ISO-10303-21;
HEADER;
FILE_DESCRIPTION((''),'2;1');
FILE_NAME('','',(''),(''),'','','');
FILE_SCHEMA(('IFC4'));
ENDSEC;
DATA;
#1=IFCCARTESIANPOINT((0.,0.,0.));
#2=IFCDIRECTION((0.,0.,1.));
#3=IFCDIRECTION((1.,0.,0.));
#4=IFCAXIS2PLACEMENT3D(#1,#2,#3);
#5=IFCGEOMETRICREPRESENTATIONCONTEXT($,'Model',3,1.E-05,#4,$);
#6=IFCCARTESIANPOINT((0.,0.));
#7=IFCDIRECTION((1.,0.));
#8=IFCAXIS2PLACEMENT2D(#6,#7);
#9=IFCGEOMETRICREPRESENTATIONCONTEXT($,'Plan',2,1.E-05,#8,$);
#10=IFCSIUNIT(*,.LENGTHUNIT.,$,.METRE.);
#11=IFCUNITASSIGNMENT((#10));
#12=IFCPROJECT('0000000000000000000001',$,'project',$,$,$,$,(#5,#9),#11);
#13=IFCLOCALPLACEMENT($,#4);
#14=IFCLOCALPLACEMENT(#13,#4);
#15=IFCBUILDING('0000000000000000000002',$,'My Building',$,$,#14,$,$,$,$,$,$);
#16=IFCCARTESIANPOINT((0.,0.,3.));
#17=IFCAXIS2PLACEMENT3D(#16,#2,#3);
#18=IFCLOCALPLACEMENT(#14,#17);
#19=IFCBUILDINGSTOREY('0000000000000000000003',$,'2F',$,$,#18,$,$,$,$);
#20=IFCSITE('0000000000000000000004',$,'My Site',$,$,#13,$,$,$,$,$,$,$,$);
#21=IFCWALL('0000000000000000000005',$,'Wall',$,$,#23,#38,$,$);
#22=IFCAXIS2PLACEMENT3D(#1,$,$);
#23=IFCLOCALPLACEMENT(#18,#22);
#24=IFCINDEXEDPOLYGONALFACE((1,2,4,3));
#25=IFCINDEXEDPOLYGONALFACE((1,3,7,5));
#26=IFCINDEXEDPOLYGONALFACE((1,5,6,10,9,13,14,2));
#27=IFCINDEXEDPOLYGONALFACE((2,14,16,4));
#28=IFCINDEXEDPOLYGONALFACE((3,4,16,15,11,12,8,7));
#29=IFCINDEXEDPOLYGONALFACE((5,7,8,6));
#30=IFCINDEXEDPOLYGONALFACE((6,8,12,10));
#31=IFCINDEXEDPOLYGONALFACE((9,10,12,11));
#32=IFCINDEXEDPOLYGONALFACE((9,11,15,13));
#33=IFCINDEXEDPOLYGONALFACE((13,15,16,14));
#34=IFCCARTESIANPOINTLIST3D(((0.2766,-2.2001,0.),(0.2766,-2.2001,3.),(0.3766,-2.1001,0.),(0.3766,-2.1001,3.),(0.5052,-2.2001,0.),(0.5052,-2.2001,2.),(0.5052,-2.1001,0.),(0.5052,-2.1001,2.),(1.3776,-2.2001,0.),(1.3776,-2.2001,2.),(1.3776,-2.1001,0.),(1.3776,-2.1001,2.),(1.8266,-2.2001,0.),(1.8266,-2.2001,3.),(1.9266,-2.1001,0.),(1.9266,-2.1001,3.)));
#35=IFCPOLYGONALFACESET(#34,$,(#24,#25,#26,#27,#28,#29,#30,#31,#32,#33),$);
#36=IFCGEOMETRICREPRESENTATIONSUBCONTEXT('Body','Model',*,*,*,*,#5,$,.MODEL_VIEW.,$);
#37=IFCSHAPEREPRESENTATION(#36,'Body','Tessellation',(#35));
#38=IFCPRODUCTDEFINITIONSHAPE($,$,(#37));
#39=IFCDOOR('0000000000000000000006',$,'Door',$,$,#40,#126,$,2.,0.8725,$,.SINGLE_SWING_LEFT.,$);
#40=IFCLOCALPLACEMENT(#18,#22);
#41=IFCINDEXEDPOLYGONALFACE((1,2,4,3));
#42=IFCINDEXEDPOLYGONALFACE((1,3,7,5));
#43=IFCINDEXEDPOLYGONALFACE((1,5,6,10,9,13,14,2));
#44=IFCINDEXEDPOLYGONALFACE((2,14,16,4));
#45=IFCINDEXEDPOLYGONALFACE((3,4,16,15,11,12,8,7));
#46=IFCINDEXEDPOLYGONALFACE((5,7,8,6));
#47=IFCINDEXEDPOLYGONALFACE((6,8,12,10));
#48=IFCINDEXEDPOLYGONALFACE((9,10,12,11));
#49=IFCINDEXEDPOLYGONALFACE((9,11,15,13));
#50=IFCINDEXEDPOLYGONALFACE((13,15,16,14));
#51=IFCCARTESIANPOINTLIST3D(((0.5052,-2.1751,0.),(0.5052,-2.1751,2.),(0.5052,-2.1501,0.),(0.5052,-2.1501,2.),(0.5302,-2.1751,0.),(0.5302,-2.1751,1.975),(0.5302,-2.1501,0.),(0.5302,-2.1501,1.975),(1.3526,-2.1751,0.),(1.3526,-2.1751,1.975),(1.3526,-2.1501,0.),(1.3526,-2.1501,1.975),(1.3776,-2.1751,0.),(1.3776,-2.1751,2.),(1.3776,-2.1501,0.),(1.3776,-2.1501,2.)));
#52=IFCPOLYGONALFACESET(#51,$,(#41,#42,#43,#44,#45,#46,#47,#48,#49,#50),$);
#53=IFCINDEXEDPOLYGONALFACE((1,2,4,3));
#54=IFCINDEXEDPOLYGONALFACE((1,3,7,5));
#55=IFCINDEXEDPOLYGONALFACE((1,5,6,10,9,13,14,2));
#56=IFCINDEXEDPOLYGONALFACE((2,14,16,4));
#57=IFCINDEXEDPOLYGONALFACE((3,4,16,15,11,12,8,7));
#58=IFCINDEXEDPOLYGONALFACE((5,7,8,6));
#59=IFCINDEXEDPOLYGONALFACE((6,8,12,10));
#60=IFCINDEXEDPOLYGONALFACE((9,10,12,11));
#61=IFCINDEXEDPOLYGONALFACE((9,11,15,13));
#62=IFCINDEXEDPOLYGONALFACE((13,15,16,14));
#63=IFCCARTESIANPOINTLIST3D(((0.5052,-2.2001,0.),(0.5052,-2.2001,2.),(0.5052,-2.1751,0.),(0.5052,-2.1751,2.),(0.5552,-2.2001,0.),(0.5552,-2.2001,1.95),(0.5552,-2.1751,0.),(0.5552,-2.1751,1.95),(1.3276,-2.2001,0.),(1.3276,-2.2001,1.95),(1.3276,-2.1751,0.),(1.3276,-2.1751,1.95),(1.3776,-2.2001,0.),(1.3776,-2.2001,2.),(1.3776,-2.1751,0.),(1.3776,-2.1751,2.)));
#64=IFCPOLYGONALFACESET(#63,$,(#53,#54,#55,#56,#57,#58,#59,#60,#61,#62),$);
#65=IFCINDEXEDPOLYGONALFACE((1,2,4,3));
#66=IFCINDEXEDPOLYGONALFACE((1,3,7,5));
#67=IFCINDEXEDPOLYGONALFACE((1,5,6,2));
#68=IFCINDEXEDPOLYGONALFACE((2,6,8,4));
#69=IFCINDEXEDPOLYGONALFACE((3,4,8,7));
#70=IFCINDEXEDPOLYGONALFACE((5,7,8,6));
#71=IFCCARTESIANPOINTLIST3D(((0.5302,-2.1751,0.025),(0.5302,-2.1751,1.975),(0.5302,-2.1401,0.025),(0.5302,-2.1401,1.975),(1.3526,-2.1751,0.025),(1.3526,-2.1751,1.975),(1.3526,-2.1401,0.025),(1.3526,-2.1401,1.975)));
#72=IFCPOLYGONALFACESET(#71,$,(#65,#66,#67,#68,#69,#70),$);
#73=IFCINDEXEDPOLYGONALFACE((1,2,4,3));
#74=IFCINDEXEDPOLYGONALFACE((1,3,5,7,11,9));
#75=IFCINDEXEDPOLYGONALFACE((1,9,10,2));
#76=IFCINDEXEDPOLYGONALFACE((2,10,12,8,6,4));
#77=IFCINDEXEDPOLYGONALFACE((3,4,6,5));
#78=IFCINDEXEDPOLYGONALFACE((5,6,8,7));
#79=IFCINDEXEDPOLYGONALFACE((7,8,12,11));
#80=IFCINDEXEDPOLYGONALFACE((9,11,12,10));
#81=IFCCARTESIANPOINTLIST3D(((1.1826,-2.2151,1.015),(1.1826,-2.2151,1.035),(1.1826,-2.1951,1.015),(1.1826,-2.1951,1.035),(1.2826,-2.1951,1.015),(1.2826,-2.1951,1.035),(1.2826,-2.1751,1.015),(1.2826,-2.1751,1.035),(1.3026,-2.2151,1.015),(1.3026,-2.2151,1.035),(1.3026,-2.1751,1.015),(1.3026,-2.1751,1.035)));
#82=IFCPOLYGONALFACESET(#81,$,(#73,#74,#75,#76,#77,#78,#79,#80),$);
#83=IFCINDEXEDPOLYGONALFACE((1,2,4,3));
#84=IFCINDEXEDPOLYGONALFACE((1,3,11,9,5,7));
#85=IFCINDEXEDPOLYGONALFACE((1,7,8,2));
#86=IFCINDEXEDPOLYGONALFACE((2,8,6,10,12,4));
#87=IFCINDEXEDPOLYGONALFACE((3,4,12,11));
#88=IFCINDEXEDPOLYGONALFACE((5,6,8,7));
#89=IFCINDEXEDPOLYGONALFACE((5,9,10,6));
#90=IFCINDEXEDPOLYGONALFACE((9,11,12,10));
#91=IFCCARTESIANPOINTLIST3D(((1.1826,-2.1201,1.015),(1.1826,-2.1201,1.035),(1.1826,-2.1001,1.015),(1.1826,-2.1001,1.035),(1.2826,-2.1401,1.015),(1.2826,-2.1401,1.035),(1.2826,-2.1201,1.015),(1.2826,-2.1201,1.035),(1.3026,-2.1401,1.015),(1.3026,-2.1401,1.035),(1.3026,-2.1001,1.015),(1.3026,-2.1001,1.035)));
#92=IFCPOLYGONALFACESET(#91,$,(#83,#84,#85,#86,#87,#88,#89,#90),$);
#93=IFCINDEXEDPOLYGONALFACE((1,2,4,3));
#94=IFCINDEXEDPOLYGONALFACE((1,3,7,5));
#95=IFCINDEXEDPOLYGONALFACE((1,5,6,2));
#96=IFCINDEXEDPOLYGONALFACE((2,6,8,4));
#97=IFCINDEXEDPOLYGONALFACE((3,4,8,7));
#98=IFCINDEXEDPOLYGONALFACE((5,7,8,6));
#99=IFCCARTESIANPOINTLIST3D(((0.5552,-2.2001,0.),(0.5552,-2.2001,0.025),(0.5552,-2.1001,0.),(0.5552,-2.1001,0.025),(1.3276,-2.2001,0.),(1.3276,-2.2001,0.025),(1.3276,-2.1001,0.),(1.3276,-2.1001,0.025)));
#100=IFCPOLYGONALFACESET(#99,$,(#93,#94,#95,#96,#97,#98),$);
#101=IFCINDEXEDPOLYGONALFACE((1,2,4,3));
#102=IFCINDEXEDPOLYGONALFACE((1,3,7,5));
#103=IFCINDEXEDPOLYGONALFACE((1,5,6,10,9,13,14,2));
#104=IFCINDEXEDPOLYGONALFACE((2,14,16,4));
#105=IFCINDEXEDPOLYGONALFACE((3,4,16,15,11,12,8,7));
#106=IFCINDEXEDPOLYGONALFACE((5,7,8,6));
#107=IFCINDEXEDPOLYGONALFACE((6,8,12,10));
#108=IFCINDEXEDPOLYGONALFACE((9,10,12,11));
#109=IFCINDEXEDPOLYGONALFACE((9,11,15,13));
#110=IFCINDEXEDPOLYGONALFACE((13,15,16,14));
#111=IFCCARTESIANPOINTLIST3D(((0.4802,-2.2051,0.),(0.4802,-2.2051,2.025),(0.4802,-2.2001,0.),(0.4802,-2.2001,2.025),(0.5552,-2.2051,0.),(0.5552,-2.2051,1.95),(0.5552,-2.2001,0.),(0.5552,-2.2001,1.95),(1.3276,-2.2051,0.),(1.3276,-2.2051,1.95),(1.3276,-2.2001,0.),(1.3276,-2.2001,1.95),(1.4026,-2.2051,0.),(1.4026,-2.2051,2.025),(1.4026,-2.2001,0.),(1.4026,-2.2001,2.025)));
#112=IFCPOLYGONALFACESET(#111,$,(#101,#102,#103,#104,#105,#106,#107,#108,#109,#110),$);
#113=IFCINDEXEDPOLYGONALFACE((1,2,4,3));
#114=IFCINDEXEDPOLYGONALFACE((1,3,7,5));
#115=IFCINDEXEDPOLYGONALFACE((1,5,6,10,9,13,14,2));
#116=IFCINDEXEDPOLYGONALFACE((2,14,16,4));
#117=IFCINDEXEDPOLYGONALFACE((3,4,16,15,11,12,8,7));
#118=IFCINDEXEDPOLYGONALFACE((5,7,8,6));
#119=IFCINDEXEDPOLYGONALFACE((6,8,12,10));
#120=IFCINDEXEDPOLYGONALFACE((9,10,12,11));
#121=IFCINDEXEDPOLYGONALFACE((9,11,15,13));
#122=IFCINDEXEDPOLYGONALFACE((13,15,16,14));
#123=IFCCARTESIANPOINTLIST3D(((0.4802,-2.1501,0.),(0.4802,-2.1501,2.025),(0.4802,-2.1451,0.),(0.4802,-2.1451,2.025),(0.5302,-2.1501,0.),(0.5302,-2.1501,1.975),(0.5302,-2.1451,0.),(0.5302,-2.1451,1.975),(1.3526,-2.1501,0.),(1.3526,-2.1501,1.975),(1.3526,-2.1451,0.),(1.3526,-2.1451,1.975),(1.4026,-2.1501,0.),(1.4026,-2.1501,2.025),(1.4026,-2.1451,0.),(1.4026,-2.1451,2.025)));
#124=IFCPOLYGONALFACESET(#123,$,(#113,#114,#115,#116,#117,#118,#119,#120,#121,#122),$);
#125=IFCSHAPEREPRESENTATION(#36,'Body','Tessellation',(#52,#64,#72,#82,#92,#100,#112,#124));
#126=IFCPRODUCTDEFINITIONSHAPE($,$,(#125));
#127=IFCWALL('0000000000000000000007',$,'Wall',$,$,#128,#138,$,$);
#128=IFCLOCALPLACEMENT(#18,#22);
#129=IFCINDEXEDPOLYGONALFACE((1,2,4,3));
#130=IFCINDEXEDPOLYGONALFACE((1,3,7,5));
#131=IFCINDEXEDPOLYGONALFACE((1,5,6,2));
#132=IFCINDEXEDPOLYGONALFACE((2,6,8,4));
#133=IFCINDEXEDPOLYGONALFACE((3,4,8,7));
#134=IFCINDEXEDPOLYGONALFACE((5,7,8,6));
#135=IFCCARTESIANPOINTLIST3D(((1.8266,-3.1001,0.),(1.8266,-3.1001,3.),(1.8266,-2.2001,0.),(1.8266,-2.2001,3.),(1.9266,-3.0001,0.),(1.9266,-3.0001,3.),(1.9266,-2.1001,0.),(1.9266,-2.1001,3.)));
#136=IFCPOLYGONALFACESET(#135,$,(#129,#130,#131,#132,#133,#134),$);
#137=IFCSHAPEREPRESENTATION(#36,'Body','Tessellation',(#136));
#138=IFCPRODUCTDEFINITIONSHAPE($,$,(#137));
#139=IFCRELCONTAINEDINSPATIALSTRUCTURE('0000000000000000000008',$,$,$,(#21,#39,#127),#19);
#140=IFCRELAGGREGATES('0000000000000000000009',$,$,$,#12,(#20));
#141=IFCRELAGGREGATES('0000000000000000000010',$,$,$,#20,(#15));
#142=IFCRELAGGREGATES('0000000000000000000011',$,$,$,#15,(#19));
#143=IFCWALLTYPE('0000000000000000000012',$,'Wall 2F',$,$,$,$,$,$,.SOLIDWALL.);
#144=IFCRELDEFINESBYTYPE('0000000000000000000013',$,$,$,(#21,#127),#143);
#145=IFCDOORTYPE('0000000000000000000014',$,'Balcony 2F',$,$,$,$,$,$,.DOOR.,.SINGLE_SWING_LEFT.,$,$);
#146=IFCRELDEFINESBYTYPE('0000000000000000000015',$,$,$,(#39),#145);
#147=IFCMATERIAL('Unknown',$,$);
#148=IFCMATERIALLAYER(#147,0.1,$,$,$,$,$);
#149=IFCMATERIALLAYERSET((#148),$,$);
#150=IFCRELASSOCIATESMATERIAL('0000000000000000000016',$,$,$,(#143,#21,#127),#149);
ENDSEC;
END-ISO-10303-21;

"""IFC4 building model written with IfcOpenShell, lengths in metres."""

from ifc_helpers import new_model, entity, si_unit, frame, origin_with_axes, origin_2d_with_axis, place, context, subcontext, project, spatial, line, indexed_curve, outline, extrude, shape, source, transform, mapped, material, layer, layer_set, layer_usage, type_object, type_shapes, element, fill, save


model = new_model("IFC4")

# Units and contexts
model_context = context("Model", 3, precision=1e-05, world=origin_with_axes())
plan_context = context("Plan", 2, precision=1e-05, world=origin_2d_with_axis())
body_context_1 = subcontext(model_context, "Body", "Model", "MODEL_VIEW")
body_context_2 = subcontext(plan_context, "Body", "Plan", "PLAN_VIEW")
ifc_project = project(units=[si_unit("LENGTHUNIT", "METRE")], contexts=[model_context, plan_context])

# Site, building, storey
site_placement = place(None, origin_with_axes())
site = spatial("IfcSite", under=ifc_project, at=site_placement, Name="My Site")
building_placement = place(site_placement, origin_with_axes())
building = spatial("IfcBuilding", under=site, at=building_placement, Name="My Building")
storey_placement = place(building_placement, frame((0.0, 0.0, 3.0), z_axis=(0.0, 0.0, 1.0), x_axis=(1.0, 0.0, 0.0)))
storey = spatial("IfcBuildingStorey", under=building, at=storey_placement, Name="2F")

# Shared definitions
ifc_material = material(Name="Unknown")
ifc_layer_1 = layer(ifc_material, 0.1)
ifc_layer_set_1 = layer_set([ifc_layer_1])
wall_type_1 = type_object("IfcWallType", Name="Wall 2F", PredefinedType="SOLIDWALL", material=ifc_layer_set_1)

# Wall, opening, door
ifc_layer_usage_1 = layer_usage(ifc_layer_set_1, "AXIS2", "POSITIVE", 0.0)
wall_1_placement = place(storey_placement, frame((0.2766, -2.2001, 0.0), z_axis=(0.0, 0.0, 1.0), x_axis=(1.0, 0.0, 0.0)))
wall_1 = element("IfcWall", 1, at=wall_1_placement, inside=storey, type_object=wall_type_1, material=ifc_layer_usage_1, Name="Wall", context=body_context_1, shape_type="SweptSolid", body=[
    extrude(outline(indexed_curve([(0.0, 0.0), (0.1, 0.1), (1.65, 0.1), (1.55, 0.0)], segments=[line(1, 2, 3, 4, 1)])), origin_with_axes(), (0.0, 0.0, 1.0), 3.0),
])
shared_shape_1 = source(origin_with_axes(), body_context_1, "Body", "SweptSolid", [
    extrude(outline(indexed_curve([(0.0, 0.0), (0.8725, 0.0), (0.8725, 2.0), (0.0, 2.0)], segments=[line(1, 2, 3, 4, 1)])), frame((0.0, -0.6, 0.0), z_axis=(0.0, -1.0, 0.0), x_axis=(1.0, 0.0, 0.0)), (0.0, 0.0, -1.0), 1.2),
])
opening_1_placement = place(wall_1_placement, frame((0.2286, 0.0, 0.0), z_axis=(0.0, 0.0, 1.0), x_axis=(1.0, 0.0, 0.0)))
opening_1 = element("IfcOpeningElement", 2, at=opening_1_placement, cuts=wall_1, PredefinedType="OPENING", context=body_context_1, shape_type="MappedRepresentation", body=[
    mapped(shared_shape_1, transform((0.0, 0.0, 0.0), x_axis=(1.0, 0.0, 0.0), y_axis=(0.0, 1.0, 0.0), z_axis=(0.0, 0.0, 1.0), scale=1.0)),
])
door_type_1 = type_object("IfcDoorType", Name="Balcony 2F", OperationType="SINGLE_SWING_LEFT", PredefinedType="DOOR")
shared_shape_2 = source(origin_with_axes(), body_context_1, "Body", "SweptSolid", [
    extrude(outline(indexed_curve([(0.0, 0.0), (0.0, 2.0), (0.8725, 2.0), (0.8725, 0.0), (0.8475, 0.0), (0.8475, 1.975), (0.025, 1.975), (0.025, 0.0)], segments=[line(1, 2, 3, 4, 5, 6, 7, 8, 1)])), frame((0.0, 0.025, 0.0), z_axis=(0.0, -1.0, 0.0), x_axis=(1.0, 0.0, 0.0)), (0.0, 0.0, -1.0), 0.025),
    extrude(outline(indexed_curve([(0.0, 0.0), (0.0, 2.0), (0.8725, 2.0), (0.8725, 0.0), (0.8225, 0.0), (0.8225, 1.95), (0.05, 1.95), (0.05, 0.0)], segments=[line(1, 2, 3, 4, 5, 6, 7, 8, 1)])), frame((0.0, 0.0, 0.0), z_axis=(0.0, -1.0, 0.0), x_axis=(1.0, 0.0, 0.0)), (0.0, 0.0, -1.0), 0.025),
    extrude(outline(indexed_curve([(0.0, 0.0), (0.8225, 0.0), (0.8225, 0.035), (0.0, 0.035)], segments=[line(1, 2, 3, 4, 1)])), frame((0.025, 0.025, 0.025), z_axis=(0.0, 0.0, 1.0), x_axis=(1.0, 0.0, 0.0)), (0.0, 0.0, 1.0), 1.95),
    extrude(outline(indexed_curve([(0.0, 0.0), (0.0, -0.04), (-0.12, -0.04), (-0.12, -0.02), (-0.02, -0.02), (-0.02, 0.0)], segments=[line(1, 2, 3, 4, 5, 6, 1)])), frame((0.7975, 0.025, 1.015), z_axis=(0.0, 0.0, 1.0), x_axis=(1.0, 0.0, 0.0)), (0.0, 0.0, 1.0), 0.02),
    extrude(outline(indexed_curve([(0.0, 0.0), (0.0, 0.04), (-0.12, 0.04), (-0.12, 0.02), (-0.02, 0.02), (-0.02, 0.0)], segments=[line(1, 2, 3, 4, 5, 6, 1)])), frame((0.7975, 0.06, 1.015), z_axis=(0.0, 0.0, 1.0), x_axis=(1.0, 0.0, 0.0)), (0.0, 0.0, 1.0), 0.02),
    extrude(outline(indexed_curve([(0.0, 0.0), (0.7725, 0.0), (0.7725, 0.1), (0.0, 0.1)], segments=[line(1, 2, 3, 4, 1)])), frame((0.05, 0.0, 0.0), z_axis=(0.0, 0.0, 1.0), x_axis=(1.0, 0.0, 0.0)), (0.0, 0.0, 1.0), 0.025),
    extrude(outline(indexed_curve([(0.0, 0.0), (0.0, 2.025), (0.9225, 2.025), (0.9225, 0.0), (0.8475, 0.0), (0.8475, 1.95), (0.075, 1.95), (0.075, 0.0)], segments=[line(1, 2, 3, 4, 5, 6, 7, 8, 1)])), frame((-0.025, -0.005, 0.0), z_axis=(0.0, -1.0, 0.0), x_axis=(1.0, 0.0, 0.0)), (0.0, 0.0, -1.0), 0.005),
    extrude(outline(indexed_curve([(0.0, 0.0), (0.0, 2.025), (0.9225, 2.025), (0.9225, 0.0), (0.8725, 0.0), (0.8725, 1.975), (0.05, 1.975), (0.05, 0.0)], segments=[line(1, 2, 3, 4, 5, 6, 7, 8, 1)])), frame((-0.025, 0.05, 0.0), z_axis=(0.0, -1.0, 0.0), x_axis=(1.0, 0.0, 0.0)), (0.0, 0.0, -1.0), 0.005),
])
shared_shape_3 = source(origin_with_axes(), body_context_2, "Body", "Curve2D", [
    entity("IfcIndexedPolyCurve", entity("IfcCartesianPointList2D", [[0.0, 0.0], [0.0, 0.05], [0.025, 0.05], [0.025, 0.025], [0.05, 0.025], [0.05, 0.0]]), [entity("IfcLineIndex", [1, 2, 3, 4, 5, 6, 1])]),
    entity("IfcIndexedPolyCurve", entity("IfcCartesianPointList2D", [[0.8725, 0.0], [0.8725, 0.05], [0.8475, 0.05], [0.8475, 0.025], [0.8225, 0.025], [0.8225, 0.0]]), [entity("IfcLineIndex", [1, 2, 3, 4, 5, 6, 1])]),
    entity("IfcTrimmedCurve", entity("IfcEllipse", entity("IfcAxis2Placement2D", entity("IfcCartesianPoint", [0.06, 0.05]), entity("IfcDirection", [1.0, 0.0])), 0.7875, 0.8225), [entity("IfcCartesianPoint", [0.8475, 0.05])], [entity("IfcCartesianPoint", [0.06, 0.8725])], True, "CARTESIAN"),
    entity("IfcIndexedPolyCurve", entity("IfcCartesianPointList2D", [[0.025, 0.05], [0.06, 0.05], [0.06, 0.8725], [0.025, 0.8725]]), [entity("IfcLineIndex", [1, 2, 3, 4, 1])]),
])
type_shapes(door_type_1, [shared_shape_2, shared_shape_3])
door_1_placement = place(opening_1_placement, frame((0.0, 0.0, 0.0), z_axis=(0.0, 0.0, 1.0), x_axis=(1.0, 0.0, 0.0)))
door_1 = element("IfcDoor", 3, at=door_1_placement, inside=storey, type_object=door_type_1, Name="Door", OperationType="SINGLE_SWING_LEFT", OverallHeight=2.0, OverallWidth=0.8725, shapes=[
    shape(body_context_1, "Body", "MappedRepresentation", [mapped(shared_shape_2, transform((0.0, 0.0, 0.0), x_axis=(1.0, 0.0, 0.0), y_axis=(0.0, 1.0, 0.0), z_axis=(0.0, 0.0, 1.0), scale=1.0))]),
    shape(body_context_2, "Body", "MappedRepresentation", [mapped(shared_shape_3, transform((0.0, 0.0, 0.0), x_axis=(1.0, 0.0, 0.0), y_axis=(0.0, 1.0, 0.0), z_axis=(0.0, 0.0, 1.0), scale=1.0))]),
])
fill(opening_1, door_1)

# Wall
ifc_layer_usage_2 = layer_usage(ifc_layer_set_1, "AXIS2", "POSITIVE", 0.0)
wall_2_placement = place(storey_placement, frame((1.8266, -2.2001, 0.0), z_axis=(0.0, 0.0, 1.0), x_axis=(0.0, -1.0, 0.0)))
element("IfcWall", 4, at=wall_2_placement, inside=storey, type_object=wall_type_1, material=ifc_layer_usage_2, Name="Wall", context=body_context_1, shape_type="SweptSolid", body=[
    extrude(outline(indexed_curve([(0.0, 0.0), (-0.1, 0.1), (0.8, 0.1), (0.9, 0.0)], segments=[line(1, 2, 3, 4, 1)])), origin_with_axes(), (0.0, 0.0, 1.0), 3.0),
])

save(model, "model.ifc")
